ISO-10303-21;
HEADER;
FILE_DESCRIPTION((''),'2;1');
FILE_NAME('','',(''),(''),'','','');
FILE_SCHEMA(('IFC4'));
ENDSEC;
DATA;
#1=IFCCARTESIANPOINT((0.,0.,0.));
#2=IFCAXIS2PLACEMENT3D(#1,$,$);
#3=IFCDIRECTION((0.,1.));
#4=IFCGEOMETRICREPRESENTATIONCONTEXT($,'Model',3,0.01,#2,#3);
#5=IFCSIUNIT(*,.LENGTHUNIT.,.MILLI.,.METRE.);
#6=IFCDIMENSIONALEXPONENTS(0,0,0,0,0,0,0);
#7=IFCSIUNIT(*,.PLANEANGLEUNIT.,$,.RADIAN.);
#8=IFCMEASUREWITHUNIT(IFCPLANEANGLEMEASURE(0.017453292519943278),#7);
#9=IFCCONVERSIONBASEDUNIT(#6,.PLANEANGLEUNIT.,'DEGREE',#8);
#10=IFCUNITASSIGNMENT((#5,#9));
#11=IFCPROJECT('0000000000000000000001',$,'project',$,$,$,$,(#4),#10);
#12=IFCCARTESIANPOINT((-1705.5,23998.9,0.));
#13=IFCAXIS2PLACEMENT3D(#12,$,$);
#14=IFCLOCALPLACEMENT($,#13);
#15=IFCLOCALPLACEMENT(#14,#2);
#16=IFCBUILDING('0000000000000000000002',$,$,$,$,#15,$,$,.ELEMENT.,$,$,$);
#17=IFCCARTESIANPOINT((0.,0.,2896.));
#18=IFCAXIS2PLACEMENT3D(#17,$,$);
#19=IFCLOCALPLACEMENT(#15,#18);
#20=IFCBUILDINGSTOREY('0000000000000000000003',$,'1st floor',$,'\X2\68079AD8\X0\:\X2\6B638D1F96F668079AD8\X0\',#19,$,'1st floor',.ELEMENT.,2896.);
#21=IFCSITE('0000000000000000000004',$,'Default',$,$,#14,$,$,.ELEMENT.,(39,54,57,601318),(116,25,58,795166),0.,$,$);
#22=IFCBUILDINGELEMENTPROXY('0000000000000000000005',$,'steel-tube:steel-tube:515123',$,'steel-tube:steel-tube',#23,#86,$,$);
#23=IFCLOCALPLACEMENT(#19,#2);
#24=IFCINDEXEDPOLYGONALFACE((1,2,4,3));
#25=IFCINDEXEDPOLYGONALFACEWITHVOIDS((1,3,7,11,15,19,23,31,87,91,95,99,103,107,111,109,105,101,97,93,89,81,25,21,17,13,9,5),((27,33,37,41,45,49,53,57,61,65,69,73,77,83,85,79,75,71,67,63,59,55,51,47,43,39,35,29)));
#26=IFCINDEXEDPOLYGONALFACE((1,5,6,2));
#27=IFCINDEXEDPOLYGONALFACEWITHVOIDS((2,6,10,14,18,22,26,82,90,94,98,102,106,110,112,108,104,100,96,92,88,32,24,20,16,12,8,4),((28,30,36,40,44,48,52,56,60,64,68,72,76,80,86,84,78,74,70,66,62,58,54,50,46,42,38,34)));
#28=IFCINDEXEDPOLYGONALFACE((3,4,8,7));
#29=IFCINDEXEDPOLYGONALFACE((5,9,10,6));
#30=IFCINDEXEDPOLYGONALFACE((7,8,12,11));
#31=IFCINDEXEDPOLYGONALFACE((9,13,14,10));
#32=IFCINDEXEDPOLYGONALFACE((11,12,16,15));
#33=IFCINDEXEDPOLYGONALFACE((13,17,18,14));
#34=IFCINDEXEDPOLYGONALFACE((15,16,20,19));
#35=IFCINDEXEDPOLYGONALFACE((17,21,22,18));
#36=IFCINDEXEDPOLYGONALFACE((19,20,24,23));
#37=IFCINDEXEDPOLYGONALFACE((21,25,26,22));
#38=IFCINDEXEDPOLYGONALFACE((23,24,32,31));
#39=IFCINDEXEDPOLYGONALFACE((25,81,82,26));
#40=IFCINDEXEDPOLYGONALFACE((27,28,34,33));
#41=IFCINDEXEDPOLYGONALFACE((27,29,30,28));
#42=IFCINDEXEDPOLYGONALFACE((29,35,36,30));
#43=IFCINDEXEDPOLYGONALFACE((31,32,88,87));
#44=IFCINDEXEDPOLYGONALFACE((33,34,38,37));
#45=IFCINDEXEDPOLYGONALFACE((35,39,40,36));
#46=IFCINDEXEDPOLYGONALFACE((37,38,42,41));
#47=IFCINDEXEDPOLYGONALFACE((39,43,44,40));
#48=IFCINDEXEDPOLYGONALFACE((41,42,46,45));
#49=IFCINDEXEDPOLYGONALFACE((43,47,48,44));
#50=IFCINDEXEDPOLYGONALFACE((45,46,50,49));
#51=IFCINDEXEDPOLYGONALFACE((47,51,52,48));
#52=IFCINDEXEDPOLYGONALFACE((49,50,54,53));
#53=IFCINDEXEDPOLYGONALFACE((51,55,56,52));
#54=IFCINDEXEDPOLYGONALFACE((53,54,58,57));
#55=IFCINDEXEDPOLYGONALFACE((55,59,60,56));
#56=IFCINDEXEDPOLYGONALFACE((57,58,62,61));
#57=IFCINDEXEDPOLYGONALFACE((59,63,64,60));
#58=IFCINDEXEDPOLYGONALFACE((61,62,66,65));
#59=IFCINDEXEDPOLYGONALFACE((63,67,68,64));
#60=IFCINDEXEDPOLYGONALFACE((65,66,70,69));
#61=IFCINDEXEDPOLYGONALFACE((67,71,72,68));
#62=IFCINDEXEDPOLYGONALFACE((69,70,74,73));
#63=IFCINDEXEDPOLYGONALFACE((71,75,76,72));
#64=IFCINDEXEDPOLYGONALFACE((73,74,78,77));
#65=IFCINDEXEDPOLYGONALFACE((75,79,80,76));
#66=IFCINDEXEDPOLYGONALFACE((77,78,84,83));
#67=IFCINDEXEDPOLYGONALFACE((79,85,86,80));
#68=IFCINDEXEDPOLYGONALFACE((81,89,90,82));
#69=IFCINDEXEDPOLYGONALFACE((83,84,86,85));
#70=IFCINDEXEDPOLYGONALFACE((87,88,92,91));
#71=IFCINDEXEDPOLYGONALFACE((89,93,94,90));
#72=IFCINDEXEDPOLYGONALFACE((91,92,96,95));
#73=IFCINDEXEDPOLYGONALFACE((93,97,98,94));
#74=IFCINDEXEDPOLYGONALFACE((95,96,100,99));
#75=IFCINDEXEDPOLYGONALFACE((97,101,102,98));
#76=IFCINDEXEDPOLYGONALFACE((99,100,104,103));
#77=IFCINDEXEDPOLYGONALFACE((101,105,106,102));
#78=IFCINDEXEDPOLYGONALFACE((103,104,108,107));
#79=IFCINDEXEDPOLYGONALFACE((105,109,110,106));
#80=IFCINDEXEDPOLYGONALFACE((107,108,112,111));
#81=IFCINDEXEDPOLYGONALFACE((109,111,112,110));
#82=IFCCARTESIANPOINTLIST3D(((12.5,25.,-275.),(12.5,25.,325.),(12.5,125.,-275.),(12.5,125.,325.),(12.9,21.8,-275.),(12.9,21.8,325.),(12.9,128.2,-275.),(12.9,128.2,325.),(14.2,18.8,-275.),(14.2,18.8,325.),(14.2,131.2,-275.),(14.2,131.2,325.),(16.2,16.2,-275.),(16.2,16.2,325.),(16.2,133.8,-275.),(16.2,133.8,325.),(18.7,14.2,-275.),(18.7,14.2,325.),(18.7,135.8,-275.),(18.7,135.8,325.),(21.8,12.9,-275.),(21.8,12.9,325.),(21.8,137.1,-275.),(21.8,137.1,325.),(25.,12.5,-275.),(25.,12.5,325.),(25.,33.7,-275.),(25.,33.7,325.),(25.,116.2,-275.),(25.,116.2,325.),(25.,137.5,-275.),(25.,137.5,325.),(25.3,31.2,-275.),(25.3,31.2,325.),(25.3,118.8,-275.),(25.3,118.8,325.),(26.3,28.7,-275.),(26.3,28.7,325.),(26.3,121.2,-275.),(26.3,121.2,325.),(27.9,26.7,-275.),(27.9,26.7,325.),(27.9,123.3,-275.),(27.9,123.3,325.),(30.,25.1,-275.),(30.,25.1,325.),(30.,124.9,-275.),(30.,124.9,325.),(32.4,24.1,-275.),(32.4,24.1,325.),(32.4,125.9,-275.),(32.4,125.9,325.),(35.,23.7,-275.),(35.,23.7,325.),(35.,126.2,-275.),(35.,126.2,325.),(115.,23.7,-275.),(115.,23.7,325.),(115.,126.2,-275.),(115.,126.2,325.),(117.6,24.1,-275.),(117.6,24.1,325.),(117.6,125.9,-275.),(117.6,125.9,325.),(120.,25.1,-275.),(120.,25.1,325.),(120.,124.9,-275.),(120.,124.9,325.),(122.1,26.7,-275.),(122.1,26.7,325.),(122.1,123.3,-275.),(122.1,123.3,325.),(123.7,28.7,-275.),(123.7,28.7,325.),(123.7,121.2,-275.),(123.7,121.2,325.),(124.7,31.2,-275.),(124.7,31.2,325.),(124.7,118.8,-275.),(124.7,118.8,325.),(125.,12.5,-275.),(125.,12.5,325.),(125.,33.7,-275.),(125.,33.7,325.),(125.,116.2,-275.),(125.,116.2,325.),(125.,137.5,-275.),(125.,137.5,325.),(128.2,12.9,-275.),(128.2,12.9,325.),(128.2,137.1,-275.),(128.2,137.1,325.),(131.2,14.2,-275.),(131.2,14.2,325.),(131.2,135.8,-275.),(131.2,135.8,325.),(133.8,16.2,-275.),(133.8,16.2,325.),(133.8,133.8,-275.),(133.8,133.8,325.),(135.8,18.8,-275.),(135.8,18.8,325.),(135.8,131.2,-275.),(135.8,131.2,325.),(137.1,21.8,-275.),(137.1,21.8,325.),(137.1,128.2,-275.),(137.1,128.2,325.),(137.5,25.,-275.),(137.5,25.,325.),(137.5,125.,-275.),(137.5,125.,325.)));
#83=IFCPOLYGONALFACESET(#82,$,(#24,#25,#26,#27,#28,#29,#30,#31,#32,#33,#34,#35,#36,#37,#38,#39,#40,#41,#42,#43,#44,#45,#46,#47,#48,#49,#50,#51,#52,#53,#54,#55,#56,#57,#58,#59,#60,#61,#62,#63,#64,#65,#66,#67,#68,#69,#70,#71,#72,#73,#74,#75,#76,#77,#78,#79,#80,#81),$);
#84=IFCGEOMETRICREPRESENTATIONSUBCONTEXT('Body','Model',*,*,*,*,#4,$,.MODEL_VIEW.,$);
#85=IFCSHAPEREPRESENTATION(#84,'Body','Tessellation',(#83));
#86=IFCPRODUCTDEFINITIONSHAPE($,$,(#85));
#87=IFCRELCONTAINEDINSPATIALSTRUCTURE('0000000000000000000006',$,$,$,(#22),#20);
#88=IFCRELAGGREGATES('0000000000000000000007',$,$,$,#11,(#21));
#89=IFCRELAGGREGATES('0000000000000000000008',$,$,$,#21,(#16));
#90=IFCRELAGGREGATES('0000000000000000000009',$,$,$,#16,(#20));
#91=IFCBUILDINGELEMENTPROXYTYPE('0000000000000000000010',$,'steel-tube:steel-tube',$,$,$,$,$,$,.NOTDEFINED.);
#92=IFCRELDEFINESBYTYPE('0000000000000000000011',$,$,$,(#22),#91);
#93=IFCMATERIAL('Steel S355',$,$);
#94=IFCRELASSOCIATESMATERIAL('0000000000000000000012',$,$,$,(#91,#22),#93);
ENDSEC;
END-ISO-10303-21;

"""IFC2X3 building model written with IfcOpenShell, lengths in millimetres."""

from ifc_helpers import new_model, entity, si_unit, converted_unit, direction, frame, frame_2d, origin, place, context, subcontext, project, spatial, polyline, circle_curve, parameter, trimmed, segment, composite_curve, outline, extrude, source, transform, mapped, material, type_object, type_shapes, element, save


model = new_model("IFC2X3")

# Units and contexts
model_context = context("Model", 3, precision=0.01, world=origin(), true_north=direction((0.0, 1.0)))
body_context = subcontext(model_context, "Body", "Model", "MODEL_VIEW")
ifc_project = project(units=[si_unit("LENGTHUNIT", "METRE", prefix="MILLI"), converted_unit("PLANEANGLEUNIT", "DEGREE", entity("IfcPlaneAngleMeasure", 0.017453292519943278), si_unit("PLANEANGLEUNIT", "RADIAN"), dimensions=[0, 0, 0, 0, 0, 0, 0])], contexts=[model_context])

# Site, building, storey
site_placement = place(None, frame((-1705.5, 23998.9, 0.0)))
site = spatial("IfcSite", under=ifc_project, at=site_placement, Name="Default", CompositionType="ELEMENT", RefLatitude=(39, 54, 57, 601318), RefLongitude=(116, 25, 58, 795166), RefElevation=0.0)
building_placement = place(site_placement, origin())
building = spatial("IfcBuilding", under=site, at=building_placement, CompositionType="ELEMENT")
storey_placement = place(building_placement, frame((0.0, 0.0, 2896.0)))
storey = spatial("IfcBuildingStorey", under=building, at=storey_placement, Name="1st floor", ObjectType="标高:正负零标高", LongName="1st floor", CompositionType="ELEMENT", Elevation=2896.0)

# Shared definitions
ifc_material_1 = material(Name="Steel S355")

# Building element proxy
building_element_proxy_type_1 = type_object("IfcBuildingElementProxyType", Name="steel-tube:steel-tube", PredefinedType="NOTDEFINED", material=ifc_material_1)
shared_shape_1 = source(origin(), body_context, "Body", "SweptSolid", [
    extrude(outline(composite_curve([segment(trimmed(circle_curve(frame_2d((50.0, -50.0), x_axis=(1.0, 0.0)), 12.5), [parameter(270.0)], [parameter(0.0)], True, "PARAMETER"), True, "CONTINUOUS"), segment(polyline([(62.5, -50.0), (62.5, 50.0)]), True, "CONTINUOUS"), segment(trimmed(circle_curve(frame_2d((50.0, 50.0), x_axis=(1.0, 0.0)), 12.5), [parameter(0.0)], [parameter(90.0)], True, "PARAMETER"), True, "CONTINUOUS"), segment(polyline([(50.0, 62.5), (-50.0, 62.5)]), True, "CONTINUOUS"), segment(trimmed(circle_curve(frame_2d((-50.0, 50.0), x_axis=(1.0, 0.0)), 12.5), [parameter(90.0)], [parameter(180.0)], True, "PARAMETER"), True, "CONTINUOUS"), segment(polyline([(-62.5, 50.0), (-62.5, -50.0)]), True, "CONTINUOUS"), segment(trimmed(circle_curve(frame_2d((-50.0, -50.0), x_axis=(1.0, 0.0)), 12.5), [parameter(180.0)], [parameter(270.0)], True, "PARAMETER"), True, "CONTINUOUS"), segment(polyline([(-50.0, -62.5), (50.0, -62.5)]), True, "CONTINUOUS")], self_intersect=False), holes=[composite_curve([segment(trimmed(circle_curve(frame_2d((-41.2, 40.0), x_axis=(1.0, 0.0)), 10.0), [parameter(90.0)], [parameter(180.0)], True, "PARAMETER"), False, "CONTINUOUS"), segment(polyline([(-41.3, 50.0), (41.2, 50.0)]), True, "CONTINUOUS"), segment(trimmed(circle_curve(frame_2d((41.2, 40.0), x_axis=(1.0, 0.0)), 10.0), [parameter(0.0)], [parameter(90.0)], True, "PARAMETER"), False, "CONTINUOUS"), segment(polyline([(51.2, 40.0), (51.2, -40.0)]), True, "CONTINUOUS"), segment(trimmed(circle_curve(frame_2d((41.2, -40.0), x_axis=(1.0, 0.0)), 10.0), [parameter(270.0)], [parameter(360.0)], True, "PARAMETER"), False, "CONTINUOUS"), segment(polyline([(41.2, -50.0), (-41.3, -50.0)]), True, "CONTINUOUS"), segment(trimmed(circle_curve(frame_2d((-41.3, -40.0), x_axis=(1.0, 0.0)), 10.0), [parameter(180.0)], [parameter(270.0)], True, "PARAMETER"), False, "CONTINUOUS"), segment(polyline([(-51.3, -40.0), (-51.3, 40.0)]), True, "CONTINUOUS")], self_intersect=False)]), frame((62.5, 62.5, -175.0)), (0.0, 0.0, 1.0), 600.0),
])
type_shapes(building_element_proxy_type_1, [shared_shape_1])
for number, where, z_axis, x_axis, name in (
    (1, (12.5, 137.5, -100.0), (0.0, 0.0, 1.0), (0.0, -1.0, 0.0), "steel-tube:steel-tube:515123"),
):
    element("IfcBuildingElementProxy", number, at=place(storey_placement, frame(where, z_axis=z_axis, x_axis=x_axis)), inside=storey, type_object=building_element_proxy_type_1, material=ifc_material_1, Name=name, ObjectType="steel-tube:steel-tube", context=body_context, shape_type="MappedRepresentation", body=[
        mapped(shared_shape_1, transform((0.0, 0.0, 0.0), scale=1.0)),
    ])

save(model, "model.ifc")
